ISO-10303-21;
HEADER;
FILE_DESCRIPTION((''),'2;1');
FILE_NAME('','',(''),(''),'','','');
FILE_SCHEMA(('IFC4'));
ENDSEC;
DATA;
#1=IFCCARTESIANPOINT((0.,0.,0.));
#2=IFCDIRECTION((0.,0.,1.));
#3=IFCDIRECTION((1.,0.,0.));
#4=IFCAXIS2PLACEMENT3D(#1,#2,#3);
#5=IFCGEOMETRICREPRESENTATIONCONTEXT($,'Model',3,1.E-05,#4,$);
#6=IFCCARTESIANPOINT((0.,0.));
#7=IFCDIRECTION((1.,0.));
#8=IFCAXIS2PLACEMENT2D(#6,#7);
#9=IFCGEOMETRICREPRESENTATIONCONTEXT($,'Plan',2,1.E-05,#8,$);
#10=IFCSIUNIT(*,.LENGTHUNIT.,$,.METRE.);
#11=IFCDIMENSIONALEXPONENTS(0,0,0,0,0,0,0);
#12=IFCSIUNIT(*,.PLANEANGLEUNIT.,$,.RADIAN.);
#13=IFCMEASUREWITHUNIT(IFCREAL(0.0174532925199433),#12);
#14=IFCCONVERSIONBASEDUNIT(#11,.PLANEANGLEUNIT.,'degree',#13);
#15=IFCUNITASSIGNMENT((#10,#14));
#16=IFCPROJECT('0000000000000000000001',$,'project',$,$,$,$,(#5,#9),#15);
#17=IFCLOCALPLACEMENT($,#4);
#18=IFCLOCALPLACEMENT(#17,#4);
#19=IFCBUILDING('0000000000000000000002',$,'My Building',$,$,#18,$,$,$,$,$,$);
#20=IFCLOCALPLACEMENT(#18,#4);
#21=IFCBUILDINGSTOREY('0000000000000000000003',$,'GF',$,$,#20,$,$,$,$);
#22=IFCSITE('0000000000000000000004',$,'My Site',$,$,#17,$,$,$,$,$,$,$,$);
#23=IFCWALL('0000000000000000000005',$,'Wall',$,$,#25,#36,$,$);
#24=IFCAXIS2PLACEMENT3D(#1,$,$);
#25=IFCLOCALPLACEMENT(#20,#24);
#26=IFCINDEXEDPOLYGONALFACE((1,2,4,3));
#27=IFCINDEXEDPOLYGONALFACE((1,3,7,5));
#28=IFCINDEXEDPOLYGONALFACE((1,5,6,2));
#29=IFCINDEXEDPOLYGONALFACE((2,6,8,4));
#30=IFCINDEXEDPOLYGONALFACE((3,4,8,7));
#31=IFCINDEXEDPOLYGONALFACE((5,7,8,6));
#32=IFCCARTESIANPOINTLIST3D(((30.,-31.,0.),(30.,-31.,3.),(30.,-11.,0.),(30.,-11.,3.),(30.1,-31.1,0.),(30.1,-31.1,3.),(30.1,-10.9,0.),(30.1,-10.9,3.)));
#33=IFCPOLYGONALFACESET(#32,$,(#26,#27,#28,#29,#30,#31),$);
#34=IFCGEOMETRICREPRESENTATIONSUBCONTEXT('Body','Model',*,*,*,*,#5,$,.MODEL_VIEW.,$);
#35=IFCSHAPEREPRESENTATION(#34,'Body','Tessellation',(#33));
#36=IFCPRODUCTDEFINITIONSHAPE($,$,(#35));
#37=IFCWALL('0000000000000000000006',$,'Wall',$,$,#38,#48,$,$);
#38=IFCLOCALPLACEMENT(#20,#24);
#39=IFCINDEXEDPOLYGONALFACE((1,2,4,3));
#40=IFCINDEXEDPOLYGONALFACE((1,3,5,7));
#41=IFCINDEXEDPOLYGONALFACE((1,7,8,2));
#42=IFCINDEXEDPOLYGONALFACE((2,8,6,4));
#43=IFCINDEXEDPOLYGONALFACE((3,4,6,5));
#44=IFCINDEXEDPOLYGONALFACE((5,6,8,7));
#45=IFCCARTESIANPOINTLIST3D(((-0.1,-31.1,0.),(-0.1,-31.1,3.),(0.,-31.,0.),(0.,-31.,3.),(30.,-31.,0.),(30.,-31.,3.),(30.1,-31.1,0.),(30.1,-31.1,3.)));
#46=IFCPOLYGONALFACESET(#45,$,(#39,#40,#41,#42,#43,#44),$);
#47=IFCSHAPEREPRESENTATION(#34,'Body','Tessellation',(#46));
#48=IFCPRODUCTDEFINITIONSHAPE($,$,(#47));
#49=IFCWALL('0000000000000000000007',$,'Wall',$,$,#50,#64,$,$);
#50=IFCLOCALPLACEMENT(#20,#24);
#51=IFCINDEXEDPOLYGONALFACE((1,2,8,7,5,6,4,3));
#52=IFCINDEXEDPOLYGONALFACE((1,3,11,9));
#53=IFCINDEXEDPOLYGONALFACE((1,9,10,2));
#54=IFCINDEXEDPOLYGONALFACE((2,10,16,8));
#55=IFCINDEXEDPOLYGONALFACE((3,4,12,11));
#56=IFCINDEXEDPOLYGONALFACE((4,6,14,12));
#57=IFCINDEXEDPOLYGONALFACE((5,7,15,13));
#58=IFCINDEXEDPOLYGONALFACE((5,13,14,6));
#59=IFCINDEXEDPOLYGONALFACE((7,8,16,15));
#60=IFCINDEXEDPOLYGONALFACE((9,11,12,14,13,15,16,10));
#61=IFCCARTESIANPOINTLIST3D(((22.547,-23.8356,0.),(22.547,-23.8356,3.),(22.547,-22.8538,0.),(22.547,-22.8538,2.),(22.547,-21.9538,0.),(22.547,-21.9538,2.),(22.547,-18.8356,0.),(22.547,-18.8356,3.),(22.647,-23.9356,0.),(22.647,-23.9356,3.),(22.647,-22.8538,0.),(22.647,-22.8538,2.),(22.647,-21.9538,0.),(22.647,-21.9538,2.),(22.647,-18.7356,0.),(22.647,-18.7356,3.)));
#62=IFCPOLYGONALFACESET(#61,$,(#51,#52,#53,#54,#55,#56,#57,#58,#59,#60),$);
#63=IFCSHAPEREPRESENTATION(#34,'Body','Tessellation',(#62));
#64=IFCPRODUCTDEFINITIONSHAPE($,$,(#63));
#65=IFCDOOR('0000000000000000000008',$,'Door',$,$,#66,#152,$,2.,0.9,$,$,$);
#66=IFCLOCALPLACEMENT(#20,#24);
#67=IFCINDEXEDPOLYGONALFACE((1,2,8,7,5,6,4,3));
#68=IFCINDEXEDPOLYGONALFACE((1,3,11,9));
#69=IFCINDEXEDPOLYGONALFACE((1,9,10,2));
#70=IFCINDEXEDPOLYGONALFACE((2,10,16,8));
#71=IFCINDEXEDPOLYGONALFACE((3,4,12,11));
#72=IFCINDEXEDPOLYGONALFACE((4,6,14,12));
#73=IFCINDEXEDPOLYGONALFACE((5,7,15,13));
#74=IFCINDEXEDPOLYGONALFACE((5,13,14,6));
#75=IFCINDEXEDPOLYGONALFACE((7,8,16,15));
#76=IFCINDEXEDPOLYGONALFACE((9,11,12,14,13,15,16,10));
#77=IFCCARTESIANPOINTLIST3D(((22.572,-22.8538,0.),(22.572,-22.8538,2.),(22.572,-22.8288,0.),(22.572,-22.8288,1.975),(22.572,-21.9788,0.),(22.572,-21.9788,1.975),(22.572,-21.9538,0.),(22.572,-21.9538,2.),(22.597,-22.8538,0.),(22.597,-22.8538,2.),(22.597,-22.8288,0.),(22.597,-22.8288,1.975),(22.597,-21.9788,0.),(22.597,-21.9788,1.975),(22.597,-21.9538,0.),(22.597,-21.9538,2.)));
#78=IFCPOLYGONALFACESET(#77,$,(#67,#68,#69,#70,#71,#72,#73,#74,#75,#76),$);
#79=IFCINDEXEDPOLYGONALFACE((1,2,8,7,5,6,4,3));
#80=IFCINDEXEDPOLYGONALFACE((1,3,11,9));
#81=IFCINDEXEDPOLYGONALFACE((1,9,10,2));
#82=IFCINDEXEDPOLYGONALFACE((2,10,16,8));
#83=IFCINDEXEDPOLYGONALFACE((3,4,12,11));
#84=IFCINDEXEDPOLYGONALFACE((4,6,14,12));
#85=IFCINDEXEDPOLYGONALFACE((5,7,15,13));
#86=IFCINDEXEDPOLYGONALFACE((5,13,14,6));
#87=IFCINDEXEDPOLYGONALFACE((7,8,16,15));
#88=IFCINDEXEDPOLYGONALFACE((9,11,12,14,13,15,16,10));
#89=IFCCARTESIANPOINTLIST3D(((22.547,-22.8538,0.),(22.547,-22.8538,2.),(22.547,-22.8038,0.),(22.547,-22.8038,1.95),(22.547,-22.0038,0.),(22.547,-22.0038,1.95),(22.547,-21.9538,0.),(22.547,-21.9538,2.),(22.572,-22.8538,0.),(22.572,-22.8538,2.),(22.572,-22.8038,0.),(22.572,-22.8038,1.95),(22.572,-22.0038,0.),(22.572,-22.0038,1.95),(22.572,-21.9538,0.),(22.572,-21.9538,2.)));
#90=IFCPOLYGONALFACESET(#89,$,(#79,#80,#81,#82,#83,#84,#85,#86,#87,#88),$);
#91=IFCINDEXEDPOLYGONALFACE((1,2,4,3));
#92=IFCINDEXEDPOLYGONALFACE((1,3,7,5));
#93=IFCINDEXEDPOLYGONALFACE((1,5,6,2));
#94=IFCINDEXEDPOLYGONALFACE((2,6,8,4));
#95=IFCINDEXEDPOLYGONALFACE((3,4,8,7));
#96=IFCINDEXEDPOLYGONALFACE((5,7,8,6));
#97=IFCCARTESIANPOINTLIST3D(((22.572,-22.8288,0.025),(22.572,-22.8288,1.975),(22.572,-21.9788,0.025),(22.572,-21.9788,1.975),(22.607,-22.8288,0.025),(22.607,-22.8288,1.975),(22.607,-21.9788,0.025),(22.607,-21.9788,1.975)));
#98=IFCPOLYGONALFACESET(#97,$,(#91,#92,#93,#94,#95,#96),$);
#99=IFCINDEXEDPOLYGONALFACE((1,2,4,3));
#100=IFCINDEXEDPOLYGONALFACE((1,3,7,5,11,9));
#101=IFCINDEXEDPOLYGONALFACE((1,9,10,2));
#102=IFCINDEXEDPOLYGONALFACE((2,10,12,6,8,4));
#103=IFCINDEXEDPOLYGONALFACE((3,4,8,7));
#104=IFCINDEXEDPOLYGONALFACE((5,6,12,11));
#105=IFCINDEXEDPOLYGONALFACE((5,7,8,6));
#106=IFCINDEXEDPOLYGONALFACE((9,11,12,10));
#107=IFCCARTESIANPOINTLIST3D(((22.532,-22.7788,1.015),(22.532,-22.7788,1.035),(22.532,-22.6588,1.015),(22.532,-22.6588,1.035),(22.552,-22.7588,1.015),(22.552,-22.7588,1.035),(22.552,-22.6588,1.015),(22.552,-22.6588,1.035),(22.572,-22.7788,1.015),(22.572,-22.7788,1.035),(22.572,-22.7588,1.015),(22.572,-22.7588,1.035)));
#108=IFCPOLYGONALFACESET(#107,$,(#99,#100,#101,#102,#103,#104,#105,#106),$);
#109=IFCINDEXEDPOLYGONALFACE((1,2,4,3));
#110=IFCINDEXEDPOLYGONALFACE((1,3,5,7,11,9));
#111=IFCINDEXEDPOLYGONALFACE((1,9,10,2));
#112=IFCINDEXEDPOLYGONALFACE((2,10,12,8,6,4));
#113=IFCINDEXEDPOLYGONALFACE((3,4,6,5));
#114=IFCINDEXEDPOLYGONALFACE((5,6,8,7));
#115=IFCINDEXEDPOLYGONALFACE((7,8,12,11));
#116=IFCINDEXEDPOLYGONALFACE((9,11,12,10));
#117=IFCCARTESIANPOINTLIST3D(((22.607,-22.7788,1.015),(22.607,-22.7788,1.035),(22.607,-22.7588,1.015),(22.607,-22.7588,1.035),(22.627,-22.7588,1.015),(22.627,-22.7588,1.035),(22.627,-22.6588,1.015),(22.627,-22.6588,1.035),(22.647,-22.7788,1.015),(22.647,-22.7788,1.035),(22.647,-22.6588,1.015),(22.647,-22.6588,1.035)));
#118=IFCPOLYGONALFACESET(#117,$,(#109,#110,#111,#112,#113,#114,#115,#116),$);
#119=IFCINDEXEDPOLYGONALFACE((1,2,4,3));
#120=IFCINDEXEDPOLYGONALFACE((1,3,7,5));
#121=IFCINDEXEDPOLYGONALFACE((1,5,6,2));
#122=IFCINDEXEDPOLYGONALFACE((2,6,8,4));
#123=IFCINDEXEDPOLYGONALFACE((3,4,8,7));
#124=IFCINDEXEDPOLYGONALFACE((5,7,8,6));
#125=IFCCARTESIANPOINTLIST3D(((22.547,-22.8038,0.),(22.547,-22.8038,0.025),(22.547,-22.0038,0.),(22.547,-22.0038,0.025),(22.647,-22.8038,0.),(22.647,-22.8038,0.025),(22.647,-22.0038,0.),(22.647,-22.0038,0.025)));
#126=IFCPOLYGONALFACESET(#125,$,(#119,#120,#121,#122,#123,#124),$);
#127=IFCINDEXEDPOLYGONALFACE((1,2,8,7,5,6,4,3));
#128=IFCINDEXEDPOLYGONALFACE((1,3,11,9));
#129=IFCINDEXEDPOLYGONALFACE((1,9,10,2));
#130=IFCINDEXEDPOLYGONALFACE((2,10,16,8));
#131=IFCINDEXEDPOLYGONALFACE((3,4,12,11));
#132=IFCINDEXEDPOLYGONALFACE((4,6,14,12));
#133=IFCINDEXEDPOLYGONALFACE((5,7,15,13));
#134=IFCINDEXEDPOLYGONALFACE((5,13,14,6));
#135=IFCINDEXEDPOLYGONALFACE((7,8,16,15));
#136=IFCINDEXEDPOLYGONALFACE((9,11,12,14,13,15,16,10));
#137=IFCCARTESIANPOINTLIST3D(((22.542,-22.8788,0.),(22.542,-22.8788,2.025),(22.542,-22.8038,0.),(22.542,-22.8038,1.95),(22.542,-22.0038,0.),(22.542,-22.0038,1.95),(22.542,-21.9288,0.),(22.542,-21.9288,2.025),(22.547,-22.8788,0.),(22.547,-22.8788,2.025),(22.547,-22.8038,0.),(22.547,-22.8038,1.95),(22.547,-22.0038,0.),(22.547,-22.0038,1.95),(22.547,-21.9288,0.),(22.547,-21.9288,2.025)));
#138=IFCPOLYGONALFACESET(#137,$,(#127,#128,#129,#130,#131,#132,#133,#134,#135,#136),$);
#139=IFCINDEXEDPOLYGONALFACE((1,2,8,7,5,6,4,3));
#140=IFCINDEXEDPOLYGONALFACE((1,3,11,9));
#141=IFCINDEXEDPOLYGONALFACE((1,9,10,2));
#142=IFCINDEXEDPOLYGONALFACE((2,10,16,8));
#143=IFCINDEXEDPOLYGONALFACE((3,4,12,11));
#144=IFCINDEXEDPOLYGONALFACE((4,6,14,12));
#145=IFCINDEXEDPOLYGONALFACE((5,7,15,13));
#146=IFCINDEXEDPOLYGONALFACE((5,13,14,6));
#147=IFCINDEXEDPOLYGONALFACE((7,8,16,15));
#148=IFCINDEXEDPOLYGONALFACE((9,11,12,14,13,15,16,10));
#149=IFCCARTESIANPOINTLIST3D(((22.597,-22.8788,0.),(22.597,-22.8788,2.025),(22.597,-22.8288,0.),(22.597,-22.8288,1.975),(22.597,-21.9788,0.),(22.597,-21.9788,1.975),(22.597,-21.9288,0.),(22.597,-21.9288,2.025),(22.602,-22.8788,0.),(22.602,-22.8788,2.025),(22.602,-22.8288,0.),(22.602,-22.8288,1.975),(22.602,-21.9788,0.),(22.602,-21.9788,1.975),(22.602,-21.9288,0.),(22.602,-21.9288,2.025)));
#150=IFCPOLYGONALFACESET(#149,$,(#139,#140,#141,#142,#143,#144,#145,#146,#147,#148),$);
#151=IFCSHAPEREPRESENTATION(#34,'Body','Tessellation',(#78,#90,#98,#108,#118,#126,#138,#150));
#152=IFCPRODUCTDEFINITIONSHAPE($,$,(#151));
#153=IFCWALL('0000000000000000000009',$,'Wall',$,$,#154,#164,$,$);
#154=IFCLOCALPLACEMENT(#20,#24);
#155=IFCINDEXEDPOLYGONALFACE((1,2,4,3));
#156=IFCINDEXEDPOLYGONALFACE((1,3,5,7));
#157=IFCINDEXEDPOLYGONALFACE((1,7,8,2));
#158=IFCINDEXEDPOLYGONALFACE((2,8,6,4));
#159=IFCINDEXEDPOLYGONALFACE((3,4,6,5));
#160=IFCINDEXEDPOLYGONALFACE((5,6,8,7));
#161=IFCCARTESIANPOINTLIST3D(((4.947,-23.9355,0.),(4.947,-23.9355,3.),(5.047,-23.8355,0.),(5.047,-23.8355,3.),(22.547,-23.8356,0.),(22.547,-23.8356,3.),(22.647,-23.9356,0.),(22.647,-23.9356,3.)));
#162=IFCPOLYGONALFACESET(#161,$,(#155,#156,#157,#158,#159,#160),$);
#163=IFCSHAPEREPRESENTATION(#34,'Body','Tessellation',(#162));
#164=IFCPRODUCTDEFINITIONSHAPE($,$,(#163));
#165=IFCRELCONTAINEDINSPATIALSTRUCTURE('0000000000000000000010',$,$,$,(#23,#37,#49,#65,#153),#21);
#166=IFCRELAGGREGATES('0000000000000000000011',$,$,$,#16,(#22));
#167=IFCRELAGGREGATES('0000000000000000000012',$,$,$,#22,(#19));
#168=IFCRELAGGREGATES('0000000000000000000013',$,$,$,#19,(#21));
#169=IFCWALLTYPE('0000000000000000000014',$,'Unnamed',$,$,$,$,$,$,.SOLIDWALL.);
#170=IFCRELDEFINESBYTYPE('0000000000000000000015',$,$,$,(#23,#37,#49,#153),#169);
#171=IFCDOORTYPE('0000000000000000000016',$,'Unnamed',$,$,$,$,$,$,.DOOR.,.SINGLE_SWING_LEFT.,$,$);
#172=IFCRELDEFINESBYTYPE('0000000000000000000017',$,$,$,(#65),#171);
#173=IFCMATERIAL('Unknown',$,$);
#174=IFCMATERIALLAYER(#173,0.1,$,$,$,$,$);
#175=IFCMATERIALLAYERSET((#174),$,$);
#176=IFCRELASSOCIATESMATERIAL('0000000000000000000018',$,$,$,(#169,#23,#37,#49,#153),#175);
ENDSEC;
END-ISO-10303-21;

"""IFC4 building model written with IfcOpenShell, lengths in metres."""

from ifc_helpers import new_model, entity, si_unit, converted_unit, frame, origin_with_axes, origin_2d_with_axis, place, context, subcontext, project, spatial, line, indexed_curve, outline, extrude, shape, source, transform, mapped, material, layer, layer_set, layer_usage, type_object, type_shapes, element, fill, save


model = new_model("IFC4")

# Units and contexts
model_context = context("Model", 3, precision=1e-05, world=origin_with_axes())
plan_context = context("Plan", 2, precision=1e-05, world=origin_2d_with_axis())
body_context_1 = subcontext(model_context, "Body", "Model", "MODEL_VIEW")
body_context_2 = subcontext(plan_context, "Body", "Plan", "PLAN_VIEW")
ifc_project = project(units=[si_unit("LENGTHUNIT", "METRE"), converted_unit("PLANEANGLEUNIT", "degree", entity("IfcReal", 0.0174532925199433), si_unit("PLANEANGLEUNIT", "RADIAN"), dimensions=[0, 0, 0, 0, 0, 0, 0])], contexts=[model_context, plan_context])

# Site, building, storey
site_placement = place(None, origin_with_axes())
site = spatial("IfcSite", under=ifc_project, at=site_placement, Name="My Site")
building_placement = place(site_placement, origin_with_axes())
building = spatial("IfcBuilding", under=site, at=building_placement, Name="My Building")
storey_placement = place(building_placement, origin_with_axes())
storey = spatial("IfcBuildingStorey", under=building, at=storey_placement, Name="GF")

# Walls
ifc_material = material(Name="Unknown")
ifc_layer = layer(ifc_material, 0.1)
ifc_layer_set = layer_set([ifc_layer])
ifc_layer_usage_1 = layer_usage(ifc_layer_set, "AXIS2", "POSITIVE", 0.0)
wall_type = type_object("IfcWallType", Name="Unnamed", PredefinedType="SOLIDWALL", material=ifc_layer_set)
wall_1_placement = place(storey_placement, frame((30.0, -11.0, 0.0), z_axis=(0.0, 0.0, 1.0), x_axis=(0.0, -1.0, 0.0)))
element("IfcWall", 1, at=wall_1_placement, inside=storey, type_object=wall_type, material=ifc_layer_usage_1, Name="Wall", context=body_context_1, shape_type="SweptSolid", body=[
    extrude(outline(indexed_curve([(0.0, 0.0), (-0.1, 0.1), (20.1, 0.1), (20.0, 0.0)], segments=[line(1, 2, 3, 4, 1)])), origin_with_axes(), (0.0, 0.0, 1.0), 3.0),
])
ifc_layer_usage_2 = layer_usage(ifc_layer_set, "AXIS2", "POSITIVE", 0.0)
wall_2_placement = place(storey_placement, frame((30.0, -31.0, 0.0), z_axis=(0.0, 0.0, 1.0), x_axis=(-1.0, 0.0, 0.0)))
element("IfcWall", 2, at=wall_2_placement, inside=storey, type_object=wall_type, material=ifc_layer_usage_2, Name="Wall", context=body_context_1, shape_type="SweptSolid", body=[
    extrude(outline(indexed_curve([(0.0, 0.0), (-0.1, 0.1), (30.1, 0.1), (30.0, 0.0)], segments=[line(1, 2, 3, 4, 1)])), origin_with_axes(), (0.0, 0.0, 1.0), 3.0),
])

# Wall, opening, door
ifc_layer_usage_3 = layer_usage(ifc_layer_set, "AXIS2", "POSITIVE", 0.0)
wall_3_placement = place(storey_placement, frame((22.547, -18.8356, 0.0), z_axis=(0.0, 0.0, 1.0), x_axis=(0.0, -1.0, 0.0)))
wall_3 = element("IfcWall", 3, at=wall_3_placement, inside=storey, type_object=wall_type, material=ifc_layer_usage_3, Name="Wall", context=body_context_1, shape_type="SweptSolid", body=[
    extrude(outline(indexed_curve([(0.0, 0.0), (-0.1, 0.1), (5.1, 0.1), (5.0, 0.0)], segments=[line(1, 2, 3, 4, 1)])), origin_with_axes(), (0.0, 0.0, 1.0), 3.0),
])
shared_shape_1 = source(origin_with_axes(), body_context_1, "Body", "SweptSolid", [
    extrude(outline(indexed_curve([(0.0, 0.0), (0.9, 0.0), (0.9, 2.0), (0.0, 2.0)], segments=[line(1, 2, 3, 4, 1)])), frame((0.0, -0.6, 0.0), z_axis=(0.0, -1.0, 0.0), x_axis=(1.0, 0.0, 0.0)), (0.0, 0.0, -1.0), 1.2),
])
opening_1_placement = place(wall_3_placement, frame((3.1182, 0.0, 0.0), z_axis=(0.0, 0.0, 1.0), x_axis=(1.0, 0.0, 0.0)))
opening_1 = element("IfcOpeningElement", 4, at=opening_1_placement, cuts=wall_3, PredefinedType="OPENING", context=body_context_1, shape_type="MappedRepresentation", body=[
    mapped(shared_shape_1, transform((0.0, 0.0, 0.0), x_axis=(1.0, 0.0, 0.0), y_axis=(0.0, 1.0, 0.0), z_axis=(0.0, 0.0, 1.0), scale=1.0)),
])
door_type = type_object("IfcDoorType", Name="Unnamed", OperationType="SINGLE_SWING_LEFT", PredefinedType="DOOR")
shared_shape_2 = source(origin_with_axes(), body_context_1, "Body", "SweptSolid", [
    extrude(outline(indexed_curve([(0.0, 0.0), (0.0, 2.0), (0.9, 2.0), (0.9, 0.0), (0.875, 0.0), (0.875, 1.975), (0.025, 1.975), (0.025, 0.0)], segments=[line(1, 2, 3, 4, 5, 6, 7, 8, 1)])), frame((0.0, 0.025, 0.0), z_axis=(0.0, -1.0, 0.0), x_axis=(1.0, 0.0, 0.0)), (0.0, 0.0, -1.0), 0.025),
    extrude(outline(indexed_curve([(0.0, 0.0), (0.0, 2.0), (0.9, 2.0), (0.9, 0.0), (0.85, 0.0), (0.85, 1.95), (0.05, 1.95), (0.05, 0.0)], segments=[line(1, 2, 3, 4, 5, 6, 7, 8, 1)])), frame((0.0, 0.0, 0.0), z_axis=(0.0, -1.0, 0.0), x_axis=(1.0, 0.0, 0.0)), (0.0, 0.0, -1.0), 0.025),
    extrude(outline(indexed_curve([(0.0, 0.0), (0.85, 0.0), (0.85, 0.035), (0.0, 0.035)], segments=[line(1, 2, 3, 4, 1)])), frame((0.025, 0.025, 0.025), z_axis=(0.0, 0.0, 1.0), x_axis=(1.0, 0.0, 0.0)), (0.0, 0.0, 1.0), 1.95),
    extrude(outline(indexed_curve([(0.0, 0.0), (0.0, -0.04), (-0.12, -0.04), (-0.12, -0.02), (-0.02, -0.02), (-0.02, 0.0)], segments=[line(1, 2, 3, 4, 5, 6, 1)])), frame((0.825, 0.025, 1.015), z_axis=(0.0, 0.0, 1.0), x_axis=(1.0, 0.0, 0.0)), (0.0, 0.0, 1.0), 0.02),
    extrude(outline(indexed_curve([(0.0, 0.0), (0.0, 0.04), (-0.12, 0.04), (-0.12, 0.02), (-0.02, 0.02), (-0.02, 0.0)], segments=[line(1, 2, 3, 4, 5, 6, 1)])), frame((0.825, 0.06, 1.015), z_axis=(0.0, 0.0, 1.0), x_axis=(1.0, 0.0, 0.0)), (0.0, 0.0, 1.0), 0.02),
    extrude(outline(indexed_curve([(0.0, 0.0), (0.8, 0.0), (0.8, 0.1), (0.0, 0.1)], segments=[line(1, 2, 3, 4, 1)])), frame((0.05, 0.0, 0.0), z_axis=(0.0, 0.0, 1.0), x_axis=(1.0, 0.0, 0.0)), (0.0, 0.0, 1.0), 0.025),
    extrude(outline(indexed_curve([(0.0, 0.0), (0.0, 2.025), (0.95, 2.025), (0.95, 0.0), (0.875, 0.0), (0.875, 1.95), (0.075, 1.95), (0.075, 0.0)], segments=[line(1, 2, 3, 4, 5, 6, 7, 8, 1)])), frame((-0.025, -0.005, 0.0), z_axis=(0.0, -1.0, 0.0), x_axis=(1.0, 0.0, 0.0)), (0.0, 0.0, -1.0), 0.005),
    extrude(outline(indexed_curve([(0.0, 0.0), (0.0, 2.025), (0.95, 2.025), (0.95, 0.0), (0.9, 0.0), (0.9, 1.975), (0.05, 1.975), (0.05, 0.0)], segments=[line(1, 2, 3, 4, 5, 6, 7, 8, 1)])), frame((-0.025, 0.05, 0.0), z_axis=(0.0, -1.0, 0.0), x_axis=(1.0, 0.0, 0.0)), (0.0, 0.0, -1.0), 0.005),
])
shared_shape_3 = source(origin_with_axes(), body_context_2, "Body", "Curve2D", [
    entity("IfcIndexedPolyCurve", entity("IfcCartesianPointList2D", [[0.0, 0.0], [0.0, 0.05], [0.025, 0.05], [0.025, 0.025], [0.05, 0.025], [0.05, 0.0]]), [entity("IfcLineIndex", [1, 2, 3, 4, 5, 6, 1])]),
    entity("IfcIndexedPolyCurve", entity("IfcCartesianPointList2D", [[0.9, 0.0], [0.9, 0.05], [0.875, 0.05], [0.875, 0.025], [0.85, 0.025], [0.85, 0.0]]), [entity("IfcLineIndex", [1, 2, 3, 4, 5, 6, 1])]),
    entity("IfcTrimmedCurve", entity("IfcEllipse", entity("IfcAxis2Placement2D", entity("IfcCartesianPoint", [0.06, 0.05]), entity("IfcDirection", [1.0, 0.0])), 0.815, 0.85), [entity("IfcCartesianPoint", [0.875, 0.05])], [entity("IfcCartesianPoint", [0.06, 0.9])], True, "CARTESIAN"),
    entity("IfcIndexedPolyCurve", entity("IfcCartesianPointList2D", [[0.025, 0.05], [0.06, 0.05], [0.06, 0.9], [0.025, 0.9]]), [entity("IfcLineIndex", [1, 2, 3, 4, 1])]),
])
type_shapes(door_type, [shared_shape_2, shared_shape_3])
door_1_placement = place(opening_1_placement, frame((0.0, 0.0, 0.0), z_axis=(0.0, 0.0, 1.0), x_axis=(1.0, 0.0, 0.0)))
door_1 = element("IfcDoor", 5, at=door_1_placement, inside=storey, type_object=door_type, Name="Door", OverallHeight=2.0, OverallWidth=0.9, shapes=[
    shape(body_context_1, "Body", "MappedRepresentation", [mapped(shared_shape_2, transform((0.0, 0.0, 0.0), x_axis=(1.0, 0.0, 0.0), y_axis=(0.0, 1.0, 0.0), z_axis=(0.0, 0.0, 1.0), scale=1.0))]),
    shape(body_context_2, "Body", "MappedRepresentation", [mapped(shared_shape_3, transform((0.0, 0.0, 0.0), x_axis=(1.0, 0.0, 0.0), y_axis=(0.0, 1.0, 0.0), z_axis=(0.0, 0.0, 1.0), scale=1.0))]),
])
fill(opening_1, door_1)

# Wall
ifc_layer_usage_4 = layer_usage(ifc_layer_set, "AXIS2", "POSITIVE", 0.0)
wall_4_placement = place(storey_placement, frame((22.547, -23.8356, 0.0), z_axis=(0.0, 0.0, 1.0), x_axis=(-1.0, 0.0, 0.0)))
element("IfcWall", 6, at=wall_4_placement, inside=storey, type_object=wall_type, material=ifc_layer_usage_4, Name="Wall", context=body_context_1, shape_type="SweptSolid", body=[
    extrude(outline(indexed_curve([(0.0, 0.0), (-0.1, 0.1), (17.6, 0.1), (17.5, 0.0)], segments=[line(1, 2, 3, 4, 1)])), origin_with_axes(), (0.0, 0.0, 1.0), 3.0),
])

save(model, "model.ifc")
